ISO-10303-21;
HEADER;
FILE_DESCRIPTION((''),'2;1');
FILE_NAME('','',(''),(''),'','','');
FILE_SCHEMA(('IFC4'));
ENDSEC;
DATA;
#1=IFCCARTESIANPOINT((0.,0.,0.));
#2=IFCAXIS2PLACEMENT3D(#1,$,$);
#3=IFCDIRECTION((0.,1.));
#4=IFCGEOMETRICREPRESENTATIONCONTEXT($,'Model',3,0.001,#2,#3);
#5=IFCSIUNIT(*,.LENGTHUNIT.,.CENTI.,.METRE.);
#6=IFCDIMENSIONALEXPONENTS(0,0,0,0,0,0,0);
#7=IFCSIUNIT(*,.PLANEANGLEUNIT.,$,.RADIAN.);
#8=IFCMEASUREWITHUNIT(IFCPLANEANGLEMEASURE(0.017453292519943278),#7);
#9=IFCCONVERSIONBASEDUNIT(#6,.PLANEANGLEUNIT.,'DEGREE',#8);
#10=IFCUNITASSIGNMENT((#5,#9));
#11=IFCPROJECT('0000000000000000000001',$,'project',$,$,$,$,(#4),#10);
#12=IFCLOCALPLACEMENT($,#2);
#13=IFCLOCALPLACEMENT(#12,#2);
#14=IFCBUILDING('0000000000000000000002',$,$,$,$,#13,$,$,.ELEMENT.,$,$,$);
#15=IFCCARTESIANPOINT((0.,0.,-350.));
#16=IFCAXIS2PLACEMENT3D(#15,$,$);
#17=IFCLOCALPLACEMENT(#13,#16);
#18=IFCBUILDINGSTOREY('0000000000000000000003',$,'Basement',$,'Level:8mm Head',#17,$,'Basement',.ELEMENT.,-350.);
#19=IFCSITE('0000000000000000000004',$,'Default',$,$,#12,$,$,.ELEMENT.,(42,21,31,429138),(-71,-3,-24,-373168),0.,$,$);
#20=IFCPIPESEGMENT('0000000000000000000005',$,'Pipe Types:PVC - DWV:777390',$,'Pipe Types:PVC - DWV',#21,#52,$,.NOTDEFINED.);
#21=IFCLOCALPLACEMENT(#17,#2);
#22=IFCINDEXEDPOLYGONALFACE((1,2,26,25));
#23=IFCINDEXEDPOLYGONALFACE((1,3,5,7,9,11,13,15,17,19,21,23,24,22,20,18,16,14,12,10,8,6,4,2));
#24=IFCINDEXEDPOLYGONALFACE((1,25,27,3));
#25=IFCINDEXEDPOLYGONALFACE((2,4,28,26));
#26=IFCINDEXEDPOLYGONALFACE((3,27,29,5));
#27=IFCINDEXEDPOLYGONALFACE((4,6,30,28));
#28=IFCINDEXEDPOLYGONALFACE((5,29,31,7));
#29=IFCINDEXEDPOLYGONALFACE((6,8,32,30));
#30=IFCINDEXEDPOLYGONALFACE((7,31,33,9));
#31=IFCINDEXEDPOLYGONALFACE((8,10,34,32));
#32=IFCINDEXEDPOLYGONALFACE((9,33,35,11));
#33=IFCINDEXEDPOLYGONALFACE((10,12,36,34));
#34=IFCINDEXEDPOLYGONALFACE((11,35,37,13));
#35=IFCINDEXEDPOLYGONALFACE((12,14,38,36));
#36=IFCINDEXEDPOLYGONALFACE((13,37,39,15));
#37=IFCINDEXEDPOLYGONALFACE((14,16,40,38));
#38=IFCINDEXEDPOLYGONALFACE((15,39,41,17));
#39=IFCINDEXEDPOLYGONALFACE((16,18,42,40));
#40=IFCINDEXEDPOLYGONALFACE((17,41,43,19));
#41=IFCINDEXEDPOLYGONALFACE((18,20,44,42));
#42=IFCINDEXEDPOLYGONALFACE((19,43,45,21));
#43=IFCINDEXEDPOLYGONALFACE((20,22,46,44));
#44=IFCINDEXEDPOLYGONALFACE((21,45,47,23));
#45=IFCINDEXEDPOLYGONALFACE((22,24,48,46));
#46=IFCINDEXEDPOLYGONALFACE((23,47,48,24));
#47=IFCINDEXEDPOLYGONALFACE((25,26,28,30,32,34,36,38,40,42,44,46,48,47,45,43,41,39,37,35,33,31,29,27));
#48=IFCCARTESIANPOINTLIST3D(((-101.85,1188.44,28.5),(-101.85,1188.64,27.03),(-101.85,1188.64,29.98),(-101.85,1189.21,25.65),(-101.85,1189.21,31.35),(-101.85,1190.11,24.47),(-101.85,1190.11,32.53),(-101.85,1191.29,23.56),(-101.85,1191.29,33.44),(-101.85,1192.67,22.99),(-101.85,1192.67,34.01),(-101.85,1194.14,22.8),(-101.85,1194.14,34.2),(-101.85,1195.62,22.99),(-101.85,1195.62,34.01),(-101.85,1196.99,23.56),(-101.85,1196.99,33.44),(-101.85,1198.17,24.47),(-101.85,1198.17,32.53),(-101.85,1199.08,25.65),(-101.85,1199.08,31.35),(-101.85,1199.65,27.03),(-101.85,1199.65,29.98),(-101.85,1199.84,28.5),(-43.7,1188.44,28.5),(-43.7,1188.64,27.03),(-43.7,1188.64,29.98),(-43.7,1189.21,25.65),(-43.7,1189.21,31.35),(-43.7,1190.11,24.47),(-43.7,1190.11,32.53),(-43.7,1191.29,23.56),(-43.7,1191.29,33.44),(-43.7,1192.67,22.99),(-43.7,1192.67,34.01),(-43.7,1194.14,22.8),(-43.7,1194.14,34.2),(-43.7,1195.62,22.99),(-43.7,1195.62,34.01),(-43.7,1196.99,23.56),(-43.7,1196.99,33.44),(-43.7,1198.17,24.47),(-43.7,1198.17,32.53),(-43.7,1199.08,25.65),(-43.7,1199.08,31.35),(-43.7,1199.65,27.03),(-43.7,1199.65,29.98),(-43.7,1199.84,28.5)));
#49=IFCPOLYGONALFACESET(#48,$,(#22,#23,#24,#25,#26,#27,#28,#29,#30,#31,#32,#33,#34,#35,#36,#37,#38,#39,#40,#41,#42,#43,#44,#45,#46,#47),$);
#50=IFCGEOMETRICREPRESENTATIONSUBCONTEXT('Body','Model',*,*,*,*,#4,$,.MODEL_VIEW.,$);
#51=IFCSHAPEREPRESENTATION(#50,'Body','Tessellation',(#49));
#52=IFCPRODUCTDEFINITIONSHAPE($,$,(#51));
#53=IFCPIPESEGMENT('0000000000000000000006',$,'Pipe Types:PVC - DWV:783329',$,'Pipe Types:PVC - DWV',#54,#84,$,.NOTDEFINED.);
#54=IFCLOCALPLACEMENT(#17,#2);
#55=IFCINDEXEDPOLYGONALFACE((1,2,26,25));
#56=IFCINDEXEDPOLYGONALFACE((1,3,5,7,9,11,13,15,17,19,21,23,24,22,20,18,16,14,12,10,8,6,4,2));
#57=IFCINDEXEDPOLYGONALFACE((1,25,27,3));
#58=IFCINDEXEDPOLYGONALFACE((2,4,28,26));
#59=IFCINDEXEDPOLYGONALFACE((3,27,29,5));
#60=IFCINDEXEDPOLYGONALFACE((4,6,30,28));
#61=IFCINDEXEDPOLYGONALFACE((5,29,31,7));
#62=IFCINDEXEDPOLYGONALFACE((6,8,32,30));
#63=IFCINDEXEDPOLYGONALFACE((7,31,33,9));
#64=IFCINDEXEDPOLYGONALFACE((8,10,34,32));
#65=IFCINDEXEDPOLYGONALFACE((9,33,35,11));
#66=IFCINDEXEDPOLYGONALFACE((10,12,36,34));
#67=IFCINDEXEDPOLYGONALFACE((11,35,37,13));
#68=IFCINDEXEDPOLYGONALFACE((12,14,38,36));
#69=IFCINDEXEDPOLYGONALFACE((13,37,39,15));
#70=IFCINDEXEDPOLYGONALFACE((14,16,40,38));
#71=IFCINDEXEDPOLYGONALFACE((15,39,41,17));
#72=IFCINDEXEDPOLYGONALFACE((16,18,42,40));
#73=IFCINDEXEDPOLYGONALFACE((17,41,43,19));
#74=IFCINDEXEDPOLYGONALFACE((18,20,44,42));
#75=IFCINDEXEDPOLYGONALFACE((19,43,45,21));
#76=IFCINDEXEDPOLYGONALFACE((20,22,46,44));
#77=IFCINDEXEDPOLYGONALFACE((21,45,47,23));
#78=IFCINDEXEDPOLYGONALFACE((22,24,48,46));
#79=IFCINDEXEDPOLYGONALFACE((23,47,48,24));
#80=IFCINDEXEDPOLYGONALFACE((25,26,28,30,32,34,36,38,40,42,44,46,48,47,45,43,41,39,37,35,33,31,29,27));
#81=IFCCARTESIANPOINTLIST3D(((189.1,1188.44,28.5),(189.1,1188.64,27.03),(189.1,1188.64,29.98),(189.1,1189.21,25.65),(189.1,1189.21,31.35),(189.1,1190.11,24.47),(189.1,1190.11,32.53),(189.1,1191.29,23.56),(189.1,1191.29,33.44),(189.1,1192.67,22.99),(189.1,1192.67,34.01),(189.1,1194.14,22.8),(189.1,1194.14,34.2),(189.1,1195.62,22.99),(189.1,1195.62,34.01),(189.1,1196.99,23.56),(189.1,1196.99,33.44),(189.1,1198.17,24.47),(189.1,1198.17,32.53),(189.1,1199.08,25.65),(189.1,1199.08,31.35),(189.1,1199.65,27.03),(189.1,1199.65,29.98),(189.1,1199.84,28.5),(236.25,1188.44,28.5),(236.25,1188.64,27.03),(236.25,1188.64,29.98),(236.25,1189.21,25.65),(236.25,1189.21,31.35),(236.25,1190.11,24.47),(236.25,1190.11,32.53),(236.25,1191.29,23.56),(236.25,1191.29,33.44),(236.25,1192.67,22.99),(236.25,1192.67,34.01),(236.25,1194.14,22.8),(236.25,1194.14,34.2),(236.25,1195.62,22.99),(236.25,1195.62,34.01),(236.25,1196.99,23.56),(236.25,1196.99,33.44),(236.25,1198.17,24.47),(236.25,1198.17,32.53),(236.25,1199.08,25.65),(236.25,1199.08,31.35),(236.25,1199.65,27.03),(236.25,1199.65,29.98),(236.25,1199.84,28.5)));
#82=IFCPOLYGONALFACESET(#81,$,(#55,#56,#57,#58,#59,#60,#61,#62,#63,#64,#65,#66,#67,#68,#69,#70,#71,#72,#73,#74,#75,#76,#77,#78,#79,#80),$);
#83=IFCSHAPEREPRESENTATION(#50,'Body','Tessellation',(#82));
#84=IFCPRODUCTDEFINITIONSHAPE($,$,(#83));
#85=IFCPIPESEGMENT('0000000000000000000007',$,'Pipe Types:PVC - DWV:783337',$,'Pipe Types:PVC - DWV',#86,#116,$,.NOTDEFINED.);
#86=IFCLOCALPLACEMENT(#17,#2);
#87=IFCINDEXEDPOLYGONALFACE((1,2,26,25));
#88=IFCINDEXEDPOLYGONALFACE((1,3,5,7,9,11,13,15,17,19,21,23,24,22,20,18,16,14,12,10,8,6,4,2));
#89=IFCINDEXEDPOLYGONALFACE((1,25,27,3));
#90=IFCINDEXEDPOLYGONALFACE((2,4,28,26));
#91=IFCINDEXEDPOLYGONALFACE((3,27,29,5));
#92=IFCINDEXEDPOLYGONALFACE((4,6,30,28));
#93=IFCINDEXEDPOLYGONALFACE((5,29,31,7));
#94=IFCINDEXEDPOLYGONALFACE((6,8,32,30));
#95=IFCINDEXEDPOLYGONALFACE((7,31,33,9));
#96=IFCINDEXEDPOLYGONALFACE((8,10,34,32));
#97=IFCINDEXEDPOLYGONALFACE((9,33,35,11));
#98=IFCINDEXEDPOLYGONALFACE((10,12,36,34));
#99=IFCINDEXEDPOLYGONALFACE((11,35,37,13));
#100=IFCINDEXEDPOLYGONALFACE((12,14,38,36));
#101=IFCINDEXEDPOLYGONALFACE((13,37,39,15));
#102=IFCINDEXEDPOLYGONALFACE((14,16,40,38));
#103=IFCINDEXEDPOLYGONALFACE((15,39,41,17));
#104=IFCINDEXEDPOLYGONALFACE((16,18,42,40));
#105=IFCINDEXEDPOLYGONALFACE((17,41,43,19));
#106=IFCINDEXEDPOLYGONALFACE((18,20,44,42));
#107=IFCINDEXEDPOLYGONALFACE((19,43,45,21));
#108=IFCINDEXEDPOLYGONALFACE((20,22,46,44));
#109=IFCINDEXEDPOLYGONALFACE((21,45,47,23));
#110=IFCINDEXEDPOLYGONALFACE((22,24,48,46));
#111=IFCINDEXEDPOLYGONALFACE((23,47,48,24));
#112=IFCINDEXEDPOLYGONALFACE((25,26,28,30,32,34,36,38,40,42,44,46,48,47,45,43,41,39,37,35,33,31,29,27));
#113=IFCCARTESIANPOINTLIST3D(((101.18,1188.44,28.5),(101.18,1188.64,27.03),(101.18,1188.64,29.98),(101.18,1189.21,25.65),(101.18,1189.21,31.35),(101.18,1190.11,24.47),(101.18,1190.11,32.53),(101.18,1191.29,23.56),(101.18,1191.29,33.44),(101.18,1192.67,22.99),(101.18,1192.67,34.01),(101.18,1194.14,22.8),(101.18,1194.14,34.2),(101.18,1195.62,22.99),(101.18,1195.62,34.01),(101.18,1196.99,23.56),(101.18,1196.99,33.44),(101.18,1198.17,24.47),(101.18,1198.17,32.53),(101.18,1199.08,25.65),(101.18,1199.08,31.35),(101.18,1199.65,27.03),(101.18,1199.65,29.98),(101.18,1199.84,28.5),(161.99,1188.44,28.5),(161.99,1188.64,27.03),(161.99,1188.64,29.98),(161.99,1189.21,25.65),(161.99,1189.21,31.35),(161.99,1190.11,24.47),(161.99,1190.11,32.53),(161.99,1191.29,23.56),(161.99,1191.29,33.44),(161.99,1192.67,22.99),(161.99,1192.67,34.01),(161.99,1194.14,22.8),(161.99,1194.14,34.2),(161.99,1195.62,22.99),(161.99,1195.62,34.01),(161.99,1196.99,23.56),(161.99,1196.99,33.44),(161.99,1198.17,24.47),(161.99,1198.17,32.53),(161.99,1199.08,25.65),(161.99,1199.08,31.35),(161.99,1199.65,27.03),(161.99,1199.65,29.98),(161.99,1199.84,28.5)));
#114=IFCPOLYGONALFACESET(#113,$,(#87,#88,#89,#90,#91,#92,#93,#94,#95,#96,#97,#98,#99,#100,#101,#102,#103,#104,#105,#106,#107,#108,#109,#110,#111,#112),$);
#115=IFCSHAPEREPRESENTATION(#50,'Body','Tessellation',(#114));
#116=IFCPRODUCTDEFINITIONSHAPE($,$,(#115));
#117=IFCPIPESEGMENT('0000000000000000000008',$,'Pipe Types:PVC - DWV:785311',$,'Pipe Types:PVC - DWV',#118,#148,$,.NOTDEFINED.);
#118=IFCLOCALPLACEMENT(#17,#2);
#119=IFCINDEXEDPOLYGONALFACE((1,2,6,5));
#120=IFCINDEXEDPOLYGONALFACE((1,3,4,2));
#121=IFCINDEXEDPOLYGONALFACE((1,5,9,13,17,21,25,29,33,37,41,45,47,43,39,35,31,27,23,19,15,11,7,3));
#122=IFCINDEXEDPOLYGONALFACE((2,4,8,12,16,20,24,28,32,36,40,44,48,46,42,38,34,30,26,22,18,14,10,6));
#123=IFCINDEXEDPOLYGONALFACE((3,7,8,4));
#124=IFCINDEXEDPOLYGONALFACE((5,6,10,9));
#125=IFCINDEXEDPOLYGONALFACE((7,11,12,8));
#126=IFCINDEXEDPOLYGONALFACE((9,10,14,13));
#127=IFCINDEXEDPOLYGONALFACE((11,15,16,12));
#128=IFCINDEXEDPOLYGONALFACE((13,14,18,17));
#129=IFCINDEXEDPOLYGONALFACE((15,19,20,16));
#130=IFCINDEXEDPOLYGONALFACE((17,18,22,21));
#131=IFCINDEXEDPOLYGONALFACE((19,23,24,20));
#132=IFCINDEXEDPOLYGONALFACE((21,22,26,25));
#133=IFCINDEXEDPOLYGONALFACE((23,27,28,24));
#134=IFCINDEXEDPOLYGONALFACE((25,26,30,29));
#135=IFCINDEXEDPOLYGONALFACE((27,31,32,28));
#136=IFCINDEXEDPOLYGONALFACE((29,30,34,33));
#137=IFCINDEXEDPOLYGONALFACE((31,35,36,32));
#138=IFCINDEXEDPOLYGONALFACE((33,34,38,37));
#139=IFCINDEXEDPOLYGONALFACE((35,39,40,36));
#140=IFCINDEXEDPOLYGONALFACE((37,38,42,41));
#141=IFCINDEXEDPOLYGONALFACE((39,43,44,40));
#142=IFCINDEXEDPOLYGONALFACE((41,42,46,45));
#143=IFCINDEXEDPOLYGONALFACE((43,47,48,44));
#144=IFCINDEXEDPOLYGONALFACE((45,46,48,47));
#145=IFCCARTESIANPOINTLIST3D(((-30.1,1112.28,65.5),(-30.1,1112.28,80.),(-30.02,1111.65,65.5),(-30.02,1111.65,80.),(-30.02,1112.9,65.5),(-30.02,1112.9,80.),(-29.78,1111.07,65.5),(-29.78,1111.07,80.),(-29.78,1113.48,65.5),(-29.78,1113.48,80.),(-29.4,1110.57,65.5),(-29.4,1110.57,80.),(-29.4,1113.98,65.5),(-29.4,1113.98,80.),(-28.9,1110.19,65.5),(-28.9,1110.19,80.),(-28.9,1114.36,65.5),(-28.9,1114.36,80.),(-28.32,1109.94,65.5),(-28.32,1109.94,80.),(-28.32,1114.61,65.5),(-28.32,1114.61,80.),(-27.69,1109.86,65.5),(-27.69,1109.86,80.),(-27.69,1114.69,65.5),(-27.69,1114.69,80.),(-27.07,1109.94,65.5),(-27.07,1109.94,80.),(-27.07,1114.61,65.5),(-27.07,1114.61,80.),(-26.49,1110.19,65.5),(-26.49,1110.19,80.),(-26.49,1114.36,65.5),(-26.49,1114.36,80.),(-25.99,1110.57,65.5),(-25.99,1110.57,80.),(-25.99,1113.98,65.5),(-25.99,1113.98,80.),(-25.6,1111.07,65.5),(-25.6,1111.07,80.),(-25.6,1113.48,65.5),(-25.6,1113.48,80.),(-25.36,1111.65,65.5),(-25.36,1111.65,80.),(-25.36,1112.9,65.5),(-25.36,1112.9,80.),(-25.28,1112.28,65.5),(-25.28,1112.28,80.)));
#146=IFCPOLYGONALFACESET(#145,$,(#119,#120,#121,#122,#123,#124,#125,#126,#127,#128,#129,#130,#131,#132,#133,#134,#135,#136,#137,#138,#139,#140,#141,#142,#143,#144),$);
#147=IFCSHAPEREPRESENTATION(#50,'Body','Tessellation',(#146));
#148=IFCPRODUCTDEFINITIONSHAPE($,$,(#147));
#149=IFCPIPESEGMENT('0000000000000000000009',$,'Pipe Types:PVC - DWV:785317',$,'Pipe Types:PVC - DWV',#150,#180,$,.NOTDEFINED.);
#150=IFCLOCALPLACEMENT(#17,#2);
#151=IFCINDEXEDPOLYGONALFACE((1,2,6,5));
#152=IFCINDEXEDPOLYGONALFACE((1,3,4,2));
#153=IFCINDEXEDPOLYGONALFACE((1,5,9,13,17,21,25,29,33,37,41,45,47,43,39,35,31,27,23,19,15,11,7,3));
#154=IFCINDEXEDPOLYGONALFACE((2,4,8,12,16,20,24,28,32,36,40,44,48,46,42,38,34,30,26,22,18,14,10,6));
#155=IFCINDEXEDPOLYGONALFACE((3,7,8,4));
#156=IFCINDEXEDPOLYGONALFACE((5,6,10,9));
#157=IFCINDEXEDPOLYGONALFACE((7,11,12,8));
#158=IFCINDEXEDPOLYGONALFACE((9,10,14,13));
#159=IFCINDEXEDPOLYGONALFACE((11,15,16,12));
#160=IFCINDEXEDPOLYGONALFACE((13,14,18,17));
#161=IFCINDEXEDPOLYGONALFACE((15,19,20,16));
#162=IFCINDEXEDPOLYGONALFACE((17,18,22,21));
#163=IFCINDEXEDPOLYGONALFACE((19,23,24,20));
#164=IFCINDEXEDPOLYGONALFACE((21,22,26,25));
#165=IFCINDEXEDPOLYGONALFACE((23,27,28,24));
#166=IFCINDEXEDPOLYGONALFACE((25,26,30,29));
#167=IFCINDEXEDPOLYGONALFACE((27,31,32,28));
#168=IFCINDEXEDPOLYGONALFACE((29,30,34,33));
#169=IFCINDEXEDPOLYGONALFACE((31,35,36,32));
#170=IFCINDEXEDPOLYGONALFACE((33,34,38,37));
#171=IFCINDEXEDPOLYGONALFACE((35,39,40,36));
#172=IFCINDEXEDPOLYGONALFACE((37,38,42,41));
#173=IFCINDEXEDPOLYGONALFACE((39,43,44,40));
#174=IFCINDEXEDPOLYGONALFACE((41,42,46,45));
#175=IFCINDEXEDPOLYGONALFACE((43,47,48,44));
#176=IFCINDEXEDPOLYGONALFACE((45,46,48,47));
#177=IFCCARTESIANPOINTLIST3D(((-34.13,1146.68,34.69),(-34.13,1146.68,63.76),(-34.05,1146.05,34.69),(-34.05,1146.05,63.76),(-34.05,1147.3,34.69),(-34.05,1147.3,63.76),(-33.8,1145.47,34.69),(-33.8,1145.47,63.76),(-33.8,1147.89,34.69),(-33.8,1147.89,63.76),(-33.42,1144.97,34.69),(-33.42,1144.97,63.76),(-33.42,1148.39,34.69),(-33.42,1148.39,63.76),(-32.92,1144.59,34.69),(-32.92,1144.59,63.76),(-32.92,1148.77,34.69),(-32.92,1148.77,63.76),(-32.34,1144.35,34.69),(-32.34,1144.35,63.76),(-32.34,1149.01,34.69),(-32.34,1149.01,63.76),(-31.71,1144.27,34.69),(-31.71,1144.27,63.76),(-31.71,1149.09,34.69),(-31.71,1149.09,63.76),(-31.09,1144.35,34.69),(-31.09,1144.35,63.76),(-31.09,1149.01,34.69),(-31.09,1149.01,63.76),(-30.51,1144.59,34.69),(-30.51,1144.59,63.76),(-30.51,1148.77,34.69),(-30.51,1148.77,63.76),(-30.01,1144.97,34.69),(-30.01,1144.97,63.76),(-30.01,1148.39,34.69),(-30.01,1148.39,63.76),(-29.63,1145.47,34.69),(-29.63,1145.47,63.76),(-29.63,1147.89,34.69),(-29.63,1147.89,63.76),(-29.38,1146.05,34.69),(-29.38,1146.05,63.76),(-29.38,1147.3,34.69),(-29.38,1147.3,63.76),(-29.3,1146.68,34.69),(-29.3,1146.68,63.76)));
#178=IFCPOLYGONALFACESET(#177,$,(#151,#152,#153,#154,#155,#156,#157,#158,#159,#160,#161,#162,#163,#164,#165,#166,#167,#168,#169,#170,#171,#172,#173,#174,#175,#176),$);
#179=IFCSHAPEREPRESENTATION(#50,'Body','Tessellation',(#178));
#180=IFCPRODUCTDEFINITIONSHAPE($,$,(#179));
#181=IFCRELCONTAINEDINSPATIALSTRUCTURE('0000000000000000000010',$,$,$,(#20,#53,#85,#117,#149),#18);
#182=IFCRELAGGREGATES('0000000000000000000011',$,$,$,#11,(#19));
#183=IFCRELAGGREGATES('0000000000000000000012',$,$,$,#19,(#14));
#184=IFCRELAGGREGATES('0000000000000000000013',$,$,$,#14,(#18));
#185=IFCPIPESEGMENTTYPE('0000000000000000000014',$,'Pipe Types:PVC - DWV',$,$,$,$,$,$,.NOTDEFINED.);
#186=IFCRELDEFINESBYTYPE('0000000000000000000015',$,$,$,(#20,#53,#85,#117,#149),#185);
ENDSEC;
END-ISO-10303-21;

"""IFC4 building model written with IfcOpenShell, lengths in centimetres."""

from ifc_helpers import new_model, entity, si_unit, converted_unit, direction, frame, origin, place, context, subcontext, project, spatial, arc, indexed_curve, outline, extrude, type_object, element, save


model = new_model("IFC4")

# Units and contexts
model_context = context("Model", 3, precision=0.001, world=origin(), true_north=direction((0.0, 1.0)))
body_context = subcontext(model_context, "Body", "Model", "MODEL_VIEW")
ifc_project = project(units=[si_unit("LENGTHUNIT", "METRE", prefix="CENTI"), converted_unit("PLANEANGLEUNIT", "DEGREE", entity("IfcPlaneAngleMeasure", 0.017453292519943278), si_unit("PLANEANGLEUNIT", "RADIAN"), dimensions=[0, 0, 0, 0, 0, 0, 0])], contexts=[model_context])

# Site, building, storey
site_placement = place(None, origin())
site = spatial("IfcSite", under=ifc_project, at=site_placement, Name="Default", CompositionType="ELEMENT", RefLatitude=(42, 21, 31, 429138), RefLongitude=(-71, -3, -24, -373168), RefElevation=0.0)
building_placement = place(site_placement, origin())
building = spatial("IfcBuilding", under=site, at=building_placement, CompositionType="ELEMENT")
storey_placement = place(building_placement, frame((0.0, 0.0, -350.0)))
storey = spatial("IfcBuildingStorey", under=building, at=storey_placement, Name="Basement", ObjectType="Level:8mm Head", LongName="Basement", CompositionType="ELEMENT", Elevation=-350.0)

# Pipe segments
pipe_segment_type = type_object("IfcPipeSegmentType", Name="Pipe Types:PVC - DWV", PredefinedType="NOTDEFINED")
pipe_segment_1_placement = place(storey_placement, origin())
element("IfcPipeSegment", 1, at=pipe_segment_1_placement, inside=storey, type_object=pipe_segment_type, Name="Pipe Types:PVC - DWV:777390", ObjectType="Pipe Types:PVC - DWV", PredefinedType="NOTDEFINED", context=body_context, shape_type="SweptSolid", body=[
    extrude(outline(indexed_curve([(5.7, 0.0), (4.03, 4.03), (0.0, 5.7), (-4.03, 4.03), (-5.7, 0.0), (-4.03, -4.03), (0.0, -5.7), (4.03, -4.03)], segments=[arc(1, 2, 3), arc(3, 4, 5), arc(5, 6, 7), arc(7, 8, 1)], self_intersect=False)), frame((-101.85, 1194.14, 28.5), z_axis=(1.0, 0.0, 0.0), x_axis=(0.0, 1.0, 0.0)), (0.0, 0.0, 1.0), 58.15),
])
pipe_segment_2_placement = place(storey_placement, origin())
element("IfcPipeSegment", 2, at=pipe_segment_2_placement, inside=storey, type_object=pipe_segment_type, Name="Pipe Types:PVC - DWV:783329", ObjectType="Pipe Types:PVC - DWV", PredefinedType="NOTDEFINED", context=body_context, shape_type="SweptSolid", body=[
    extrude(outline(indexed_curve([(5.7, 0.0), (4.03, 4.03), (0.0, 5.7), (-4.03, 4.03), (-5.7, 0.0), (-4.03, -4.03), (0.0, -5.7), (4.03, -4.03)], segments=[arc(1, 2, 3), arc(3, 4, 5), arc(5, 6, 7), arc(7, 8, 1)], self_intersect=False)), frame((189.1, 1194.14, 28.5), z_axis=(1.0, 0.0, 0.0), x_axis=(0.0, -1.0, 0.0)), (0.0, 0.0, 1.0), 47.16),
])
pipe_segment_3_placement = place(storey_placement, origin())
element("IfcPipeSegment", 3, at=pipe_segment_3_placement, inside=storey, type_object=pipe_segment_type, Name="Pipe Types:PVC - DWV:783337", ObjectType="Pipe Types:PVC - DWV", PredefinedType="NOTDEFINED", context=body_context, shape_type="SweptSolid", body=[
    extrude(outline(indexed_curve([(5.7, 0.0), (4.03, 4.03), (0.0, 5.7), (-4.03, 4.03), (-5.7, 0.0), (-4.03, -4.03), (0.0, -5.7), (4.03, -4.03)], segments=[arc(1, 2, 3), arc(3, 4, 5), arc(5, 6, 7), arc(7, 8, 1)], self_intersect=False)), frame((101.18, 1194.14, 28.5), z_axis=(1.0, 0.0, 0.0), x_axis=(0.0, 1.0, 0.0)), (0.0, 0.0, 1.0), 60.81),
])
pipe_segment_4_placement = place(storey_placement, origin())
element("IfcPipeSegment", 4, at=pipe_segment_4_placement, inside=storey, type_object=pipe_segment_type, Name="Pipe Types:PVC - DWV:785311", ObjectType="Pipe Types:PVC - DWV", PredefinedType="NOTDEFINED", context=body_context, shape_type="SweptSolid", body=[
    extrude(outline(indexed_curve([(2.41, 0.0), (1.71, 1.71), (0.0, 2.41), (-1.71, 1.71), (-2.41, 0.0), (-1.71, -1.71), (0.0, -2.41), (1.71, -1.71)], segments=[arc(1, 2, 3), arc(3, 4, 5), arc(5, 6, 7), arc(7, 8, 1)], self_intersect=False)), frame((-27.69, 1112.28, 65.5)), (0.0, 0.0, 1.0), 14.5),
])
pipe_segment_5_placement = place(storey_placement, origin())
element("IfcPipeSegment", 5, at=pipe_segment_5_placement, inside=storey, type_object=pipe_segment_type, Name="Pipe Types:PVC - DWV:785317", ObjectType="Pipe Types:PVC - DWV", PredefinedType="NOTDEFINED", context=body_context, shape_type="SweptSolid", body=[
    extrude(outline(indexed_curve([(2.41, 0.0), (1.71, 1.71), (0.0, 2.41), (-1.71, 1.71), (-2.41, 0.0), (-1.71, -1.71), (0.0, -2.41), (1.71, -1.71)], segments=[arc(1, 2, 3), arc(3, 4, 5), arc(5, 6, 7), arc(7, 8, 1)], self_intersect=False)), frame((-31.71, 1146.68, 34.69)), (0.0, 0.0, 1.0), 29.07),
])

save(model, "model.ifc")
